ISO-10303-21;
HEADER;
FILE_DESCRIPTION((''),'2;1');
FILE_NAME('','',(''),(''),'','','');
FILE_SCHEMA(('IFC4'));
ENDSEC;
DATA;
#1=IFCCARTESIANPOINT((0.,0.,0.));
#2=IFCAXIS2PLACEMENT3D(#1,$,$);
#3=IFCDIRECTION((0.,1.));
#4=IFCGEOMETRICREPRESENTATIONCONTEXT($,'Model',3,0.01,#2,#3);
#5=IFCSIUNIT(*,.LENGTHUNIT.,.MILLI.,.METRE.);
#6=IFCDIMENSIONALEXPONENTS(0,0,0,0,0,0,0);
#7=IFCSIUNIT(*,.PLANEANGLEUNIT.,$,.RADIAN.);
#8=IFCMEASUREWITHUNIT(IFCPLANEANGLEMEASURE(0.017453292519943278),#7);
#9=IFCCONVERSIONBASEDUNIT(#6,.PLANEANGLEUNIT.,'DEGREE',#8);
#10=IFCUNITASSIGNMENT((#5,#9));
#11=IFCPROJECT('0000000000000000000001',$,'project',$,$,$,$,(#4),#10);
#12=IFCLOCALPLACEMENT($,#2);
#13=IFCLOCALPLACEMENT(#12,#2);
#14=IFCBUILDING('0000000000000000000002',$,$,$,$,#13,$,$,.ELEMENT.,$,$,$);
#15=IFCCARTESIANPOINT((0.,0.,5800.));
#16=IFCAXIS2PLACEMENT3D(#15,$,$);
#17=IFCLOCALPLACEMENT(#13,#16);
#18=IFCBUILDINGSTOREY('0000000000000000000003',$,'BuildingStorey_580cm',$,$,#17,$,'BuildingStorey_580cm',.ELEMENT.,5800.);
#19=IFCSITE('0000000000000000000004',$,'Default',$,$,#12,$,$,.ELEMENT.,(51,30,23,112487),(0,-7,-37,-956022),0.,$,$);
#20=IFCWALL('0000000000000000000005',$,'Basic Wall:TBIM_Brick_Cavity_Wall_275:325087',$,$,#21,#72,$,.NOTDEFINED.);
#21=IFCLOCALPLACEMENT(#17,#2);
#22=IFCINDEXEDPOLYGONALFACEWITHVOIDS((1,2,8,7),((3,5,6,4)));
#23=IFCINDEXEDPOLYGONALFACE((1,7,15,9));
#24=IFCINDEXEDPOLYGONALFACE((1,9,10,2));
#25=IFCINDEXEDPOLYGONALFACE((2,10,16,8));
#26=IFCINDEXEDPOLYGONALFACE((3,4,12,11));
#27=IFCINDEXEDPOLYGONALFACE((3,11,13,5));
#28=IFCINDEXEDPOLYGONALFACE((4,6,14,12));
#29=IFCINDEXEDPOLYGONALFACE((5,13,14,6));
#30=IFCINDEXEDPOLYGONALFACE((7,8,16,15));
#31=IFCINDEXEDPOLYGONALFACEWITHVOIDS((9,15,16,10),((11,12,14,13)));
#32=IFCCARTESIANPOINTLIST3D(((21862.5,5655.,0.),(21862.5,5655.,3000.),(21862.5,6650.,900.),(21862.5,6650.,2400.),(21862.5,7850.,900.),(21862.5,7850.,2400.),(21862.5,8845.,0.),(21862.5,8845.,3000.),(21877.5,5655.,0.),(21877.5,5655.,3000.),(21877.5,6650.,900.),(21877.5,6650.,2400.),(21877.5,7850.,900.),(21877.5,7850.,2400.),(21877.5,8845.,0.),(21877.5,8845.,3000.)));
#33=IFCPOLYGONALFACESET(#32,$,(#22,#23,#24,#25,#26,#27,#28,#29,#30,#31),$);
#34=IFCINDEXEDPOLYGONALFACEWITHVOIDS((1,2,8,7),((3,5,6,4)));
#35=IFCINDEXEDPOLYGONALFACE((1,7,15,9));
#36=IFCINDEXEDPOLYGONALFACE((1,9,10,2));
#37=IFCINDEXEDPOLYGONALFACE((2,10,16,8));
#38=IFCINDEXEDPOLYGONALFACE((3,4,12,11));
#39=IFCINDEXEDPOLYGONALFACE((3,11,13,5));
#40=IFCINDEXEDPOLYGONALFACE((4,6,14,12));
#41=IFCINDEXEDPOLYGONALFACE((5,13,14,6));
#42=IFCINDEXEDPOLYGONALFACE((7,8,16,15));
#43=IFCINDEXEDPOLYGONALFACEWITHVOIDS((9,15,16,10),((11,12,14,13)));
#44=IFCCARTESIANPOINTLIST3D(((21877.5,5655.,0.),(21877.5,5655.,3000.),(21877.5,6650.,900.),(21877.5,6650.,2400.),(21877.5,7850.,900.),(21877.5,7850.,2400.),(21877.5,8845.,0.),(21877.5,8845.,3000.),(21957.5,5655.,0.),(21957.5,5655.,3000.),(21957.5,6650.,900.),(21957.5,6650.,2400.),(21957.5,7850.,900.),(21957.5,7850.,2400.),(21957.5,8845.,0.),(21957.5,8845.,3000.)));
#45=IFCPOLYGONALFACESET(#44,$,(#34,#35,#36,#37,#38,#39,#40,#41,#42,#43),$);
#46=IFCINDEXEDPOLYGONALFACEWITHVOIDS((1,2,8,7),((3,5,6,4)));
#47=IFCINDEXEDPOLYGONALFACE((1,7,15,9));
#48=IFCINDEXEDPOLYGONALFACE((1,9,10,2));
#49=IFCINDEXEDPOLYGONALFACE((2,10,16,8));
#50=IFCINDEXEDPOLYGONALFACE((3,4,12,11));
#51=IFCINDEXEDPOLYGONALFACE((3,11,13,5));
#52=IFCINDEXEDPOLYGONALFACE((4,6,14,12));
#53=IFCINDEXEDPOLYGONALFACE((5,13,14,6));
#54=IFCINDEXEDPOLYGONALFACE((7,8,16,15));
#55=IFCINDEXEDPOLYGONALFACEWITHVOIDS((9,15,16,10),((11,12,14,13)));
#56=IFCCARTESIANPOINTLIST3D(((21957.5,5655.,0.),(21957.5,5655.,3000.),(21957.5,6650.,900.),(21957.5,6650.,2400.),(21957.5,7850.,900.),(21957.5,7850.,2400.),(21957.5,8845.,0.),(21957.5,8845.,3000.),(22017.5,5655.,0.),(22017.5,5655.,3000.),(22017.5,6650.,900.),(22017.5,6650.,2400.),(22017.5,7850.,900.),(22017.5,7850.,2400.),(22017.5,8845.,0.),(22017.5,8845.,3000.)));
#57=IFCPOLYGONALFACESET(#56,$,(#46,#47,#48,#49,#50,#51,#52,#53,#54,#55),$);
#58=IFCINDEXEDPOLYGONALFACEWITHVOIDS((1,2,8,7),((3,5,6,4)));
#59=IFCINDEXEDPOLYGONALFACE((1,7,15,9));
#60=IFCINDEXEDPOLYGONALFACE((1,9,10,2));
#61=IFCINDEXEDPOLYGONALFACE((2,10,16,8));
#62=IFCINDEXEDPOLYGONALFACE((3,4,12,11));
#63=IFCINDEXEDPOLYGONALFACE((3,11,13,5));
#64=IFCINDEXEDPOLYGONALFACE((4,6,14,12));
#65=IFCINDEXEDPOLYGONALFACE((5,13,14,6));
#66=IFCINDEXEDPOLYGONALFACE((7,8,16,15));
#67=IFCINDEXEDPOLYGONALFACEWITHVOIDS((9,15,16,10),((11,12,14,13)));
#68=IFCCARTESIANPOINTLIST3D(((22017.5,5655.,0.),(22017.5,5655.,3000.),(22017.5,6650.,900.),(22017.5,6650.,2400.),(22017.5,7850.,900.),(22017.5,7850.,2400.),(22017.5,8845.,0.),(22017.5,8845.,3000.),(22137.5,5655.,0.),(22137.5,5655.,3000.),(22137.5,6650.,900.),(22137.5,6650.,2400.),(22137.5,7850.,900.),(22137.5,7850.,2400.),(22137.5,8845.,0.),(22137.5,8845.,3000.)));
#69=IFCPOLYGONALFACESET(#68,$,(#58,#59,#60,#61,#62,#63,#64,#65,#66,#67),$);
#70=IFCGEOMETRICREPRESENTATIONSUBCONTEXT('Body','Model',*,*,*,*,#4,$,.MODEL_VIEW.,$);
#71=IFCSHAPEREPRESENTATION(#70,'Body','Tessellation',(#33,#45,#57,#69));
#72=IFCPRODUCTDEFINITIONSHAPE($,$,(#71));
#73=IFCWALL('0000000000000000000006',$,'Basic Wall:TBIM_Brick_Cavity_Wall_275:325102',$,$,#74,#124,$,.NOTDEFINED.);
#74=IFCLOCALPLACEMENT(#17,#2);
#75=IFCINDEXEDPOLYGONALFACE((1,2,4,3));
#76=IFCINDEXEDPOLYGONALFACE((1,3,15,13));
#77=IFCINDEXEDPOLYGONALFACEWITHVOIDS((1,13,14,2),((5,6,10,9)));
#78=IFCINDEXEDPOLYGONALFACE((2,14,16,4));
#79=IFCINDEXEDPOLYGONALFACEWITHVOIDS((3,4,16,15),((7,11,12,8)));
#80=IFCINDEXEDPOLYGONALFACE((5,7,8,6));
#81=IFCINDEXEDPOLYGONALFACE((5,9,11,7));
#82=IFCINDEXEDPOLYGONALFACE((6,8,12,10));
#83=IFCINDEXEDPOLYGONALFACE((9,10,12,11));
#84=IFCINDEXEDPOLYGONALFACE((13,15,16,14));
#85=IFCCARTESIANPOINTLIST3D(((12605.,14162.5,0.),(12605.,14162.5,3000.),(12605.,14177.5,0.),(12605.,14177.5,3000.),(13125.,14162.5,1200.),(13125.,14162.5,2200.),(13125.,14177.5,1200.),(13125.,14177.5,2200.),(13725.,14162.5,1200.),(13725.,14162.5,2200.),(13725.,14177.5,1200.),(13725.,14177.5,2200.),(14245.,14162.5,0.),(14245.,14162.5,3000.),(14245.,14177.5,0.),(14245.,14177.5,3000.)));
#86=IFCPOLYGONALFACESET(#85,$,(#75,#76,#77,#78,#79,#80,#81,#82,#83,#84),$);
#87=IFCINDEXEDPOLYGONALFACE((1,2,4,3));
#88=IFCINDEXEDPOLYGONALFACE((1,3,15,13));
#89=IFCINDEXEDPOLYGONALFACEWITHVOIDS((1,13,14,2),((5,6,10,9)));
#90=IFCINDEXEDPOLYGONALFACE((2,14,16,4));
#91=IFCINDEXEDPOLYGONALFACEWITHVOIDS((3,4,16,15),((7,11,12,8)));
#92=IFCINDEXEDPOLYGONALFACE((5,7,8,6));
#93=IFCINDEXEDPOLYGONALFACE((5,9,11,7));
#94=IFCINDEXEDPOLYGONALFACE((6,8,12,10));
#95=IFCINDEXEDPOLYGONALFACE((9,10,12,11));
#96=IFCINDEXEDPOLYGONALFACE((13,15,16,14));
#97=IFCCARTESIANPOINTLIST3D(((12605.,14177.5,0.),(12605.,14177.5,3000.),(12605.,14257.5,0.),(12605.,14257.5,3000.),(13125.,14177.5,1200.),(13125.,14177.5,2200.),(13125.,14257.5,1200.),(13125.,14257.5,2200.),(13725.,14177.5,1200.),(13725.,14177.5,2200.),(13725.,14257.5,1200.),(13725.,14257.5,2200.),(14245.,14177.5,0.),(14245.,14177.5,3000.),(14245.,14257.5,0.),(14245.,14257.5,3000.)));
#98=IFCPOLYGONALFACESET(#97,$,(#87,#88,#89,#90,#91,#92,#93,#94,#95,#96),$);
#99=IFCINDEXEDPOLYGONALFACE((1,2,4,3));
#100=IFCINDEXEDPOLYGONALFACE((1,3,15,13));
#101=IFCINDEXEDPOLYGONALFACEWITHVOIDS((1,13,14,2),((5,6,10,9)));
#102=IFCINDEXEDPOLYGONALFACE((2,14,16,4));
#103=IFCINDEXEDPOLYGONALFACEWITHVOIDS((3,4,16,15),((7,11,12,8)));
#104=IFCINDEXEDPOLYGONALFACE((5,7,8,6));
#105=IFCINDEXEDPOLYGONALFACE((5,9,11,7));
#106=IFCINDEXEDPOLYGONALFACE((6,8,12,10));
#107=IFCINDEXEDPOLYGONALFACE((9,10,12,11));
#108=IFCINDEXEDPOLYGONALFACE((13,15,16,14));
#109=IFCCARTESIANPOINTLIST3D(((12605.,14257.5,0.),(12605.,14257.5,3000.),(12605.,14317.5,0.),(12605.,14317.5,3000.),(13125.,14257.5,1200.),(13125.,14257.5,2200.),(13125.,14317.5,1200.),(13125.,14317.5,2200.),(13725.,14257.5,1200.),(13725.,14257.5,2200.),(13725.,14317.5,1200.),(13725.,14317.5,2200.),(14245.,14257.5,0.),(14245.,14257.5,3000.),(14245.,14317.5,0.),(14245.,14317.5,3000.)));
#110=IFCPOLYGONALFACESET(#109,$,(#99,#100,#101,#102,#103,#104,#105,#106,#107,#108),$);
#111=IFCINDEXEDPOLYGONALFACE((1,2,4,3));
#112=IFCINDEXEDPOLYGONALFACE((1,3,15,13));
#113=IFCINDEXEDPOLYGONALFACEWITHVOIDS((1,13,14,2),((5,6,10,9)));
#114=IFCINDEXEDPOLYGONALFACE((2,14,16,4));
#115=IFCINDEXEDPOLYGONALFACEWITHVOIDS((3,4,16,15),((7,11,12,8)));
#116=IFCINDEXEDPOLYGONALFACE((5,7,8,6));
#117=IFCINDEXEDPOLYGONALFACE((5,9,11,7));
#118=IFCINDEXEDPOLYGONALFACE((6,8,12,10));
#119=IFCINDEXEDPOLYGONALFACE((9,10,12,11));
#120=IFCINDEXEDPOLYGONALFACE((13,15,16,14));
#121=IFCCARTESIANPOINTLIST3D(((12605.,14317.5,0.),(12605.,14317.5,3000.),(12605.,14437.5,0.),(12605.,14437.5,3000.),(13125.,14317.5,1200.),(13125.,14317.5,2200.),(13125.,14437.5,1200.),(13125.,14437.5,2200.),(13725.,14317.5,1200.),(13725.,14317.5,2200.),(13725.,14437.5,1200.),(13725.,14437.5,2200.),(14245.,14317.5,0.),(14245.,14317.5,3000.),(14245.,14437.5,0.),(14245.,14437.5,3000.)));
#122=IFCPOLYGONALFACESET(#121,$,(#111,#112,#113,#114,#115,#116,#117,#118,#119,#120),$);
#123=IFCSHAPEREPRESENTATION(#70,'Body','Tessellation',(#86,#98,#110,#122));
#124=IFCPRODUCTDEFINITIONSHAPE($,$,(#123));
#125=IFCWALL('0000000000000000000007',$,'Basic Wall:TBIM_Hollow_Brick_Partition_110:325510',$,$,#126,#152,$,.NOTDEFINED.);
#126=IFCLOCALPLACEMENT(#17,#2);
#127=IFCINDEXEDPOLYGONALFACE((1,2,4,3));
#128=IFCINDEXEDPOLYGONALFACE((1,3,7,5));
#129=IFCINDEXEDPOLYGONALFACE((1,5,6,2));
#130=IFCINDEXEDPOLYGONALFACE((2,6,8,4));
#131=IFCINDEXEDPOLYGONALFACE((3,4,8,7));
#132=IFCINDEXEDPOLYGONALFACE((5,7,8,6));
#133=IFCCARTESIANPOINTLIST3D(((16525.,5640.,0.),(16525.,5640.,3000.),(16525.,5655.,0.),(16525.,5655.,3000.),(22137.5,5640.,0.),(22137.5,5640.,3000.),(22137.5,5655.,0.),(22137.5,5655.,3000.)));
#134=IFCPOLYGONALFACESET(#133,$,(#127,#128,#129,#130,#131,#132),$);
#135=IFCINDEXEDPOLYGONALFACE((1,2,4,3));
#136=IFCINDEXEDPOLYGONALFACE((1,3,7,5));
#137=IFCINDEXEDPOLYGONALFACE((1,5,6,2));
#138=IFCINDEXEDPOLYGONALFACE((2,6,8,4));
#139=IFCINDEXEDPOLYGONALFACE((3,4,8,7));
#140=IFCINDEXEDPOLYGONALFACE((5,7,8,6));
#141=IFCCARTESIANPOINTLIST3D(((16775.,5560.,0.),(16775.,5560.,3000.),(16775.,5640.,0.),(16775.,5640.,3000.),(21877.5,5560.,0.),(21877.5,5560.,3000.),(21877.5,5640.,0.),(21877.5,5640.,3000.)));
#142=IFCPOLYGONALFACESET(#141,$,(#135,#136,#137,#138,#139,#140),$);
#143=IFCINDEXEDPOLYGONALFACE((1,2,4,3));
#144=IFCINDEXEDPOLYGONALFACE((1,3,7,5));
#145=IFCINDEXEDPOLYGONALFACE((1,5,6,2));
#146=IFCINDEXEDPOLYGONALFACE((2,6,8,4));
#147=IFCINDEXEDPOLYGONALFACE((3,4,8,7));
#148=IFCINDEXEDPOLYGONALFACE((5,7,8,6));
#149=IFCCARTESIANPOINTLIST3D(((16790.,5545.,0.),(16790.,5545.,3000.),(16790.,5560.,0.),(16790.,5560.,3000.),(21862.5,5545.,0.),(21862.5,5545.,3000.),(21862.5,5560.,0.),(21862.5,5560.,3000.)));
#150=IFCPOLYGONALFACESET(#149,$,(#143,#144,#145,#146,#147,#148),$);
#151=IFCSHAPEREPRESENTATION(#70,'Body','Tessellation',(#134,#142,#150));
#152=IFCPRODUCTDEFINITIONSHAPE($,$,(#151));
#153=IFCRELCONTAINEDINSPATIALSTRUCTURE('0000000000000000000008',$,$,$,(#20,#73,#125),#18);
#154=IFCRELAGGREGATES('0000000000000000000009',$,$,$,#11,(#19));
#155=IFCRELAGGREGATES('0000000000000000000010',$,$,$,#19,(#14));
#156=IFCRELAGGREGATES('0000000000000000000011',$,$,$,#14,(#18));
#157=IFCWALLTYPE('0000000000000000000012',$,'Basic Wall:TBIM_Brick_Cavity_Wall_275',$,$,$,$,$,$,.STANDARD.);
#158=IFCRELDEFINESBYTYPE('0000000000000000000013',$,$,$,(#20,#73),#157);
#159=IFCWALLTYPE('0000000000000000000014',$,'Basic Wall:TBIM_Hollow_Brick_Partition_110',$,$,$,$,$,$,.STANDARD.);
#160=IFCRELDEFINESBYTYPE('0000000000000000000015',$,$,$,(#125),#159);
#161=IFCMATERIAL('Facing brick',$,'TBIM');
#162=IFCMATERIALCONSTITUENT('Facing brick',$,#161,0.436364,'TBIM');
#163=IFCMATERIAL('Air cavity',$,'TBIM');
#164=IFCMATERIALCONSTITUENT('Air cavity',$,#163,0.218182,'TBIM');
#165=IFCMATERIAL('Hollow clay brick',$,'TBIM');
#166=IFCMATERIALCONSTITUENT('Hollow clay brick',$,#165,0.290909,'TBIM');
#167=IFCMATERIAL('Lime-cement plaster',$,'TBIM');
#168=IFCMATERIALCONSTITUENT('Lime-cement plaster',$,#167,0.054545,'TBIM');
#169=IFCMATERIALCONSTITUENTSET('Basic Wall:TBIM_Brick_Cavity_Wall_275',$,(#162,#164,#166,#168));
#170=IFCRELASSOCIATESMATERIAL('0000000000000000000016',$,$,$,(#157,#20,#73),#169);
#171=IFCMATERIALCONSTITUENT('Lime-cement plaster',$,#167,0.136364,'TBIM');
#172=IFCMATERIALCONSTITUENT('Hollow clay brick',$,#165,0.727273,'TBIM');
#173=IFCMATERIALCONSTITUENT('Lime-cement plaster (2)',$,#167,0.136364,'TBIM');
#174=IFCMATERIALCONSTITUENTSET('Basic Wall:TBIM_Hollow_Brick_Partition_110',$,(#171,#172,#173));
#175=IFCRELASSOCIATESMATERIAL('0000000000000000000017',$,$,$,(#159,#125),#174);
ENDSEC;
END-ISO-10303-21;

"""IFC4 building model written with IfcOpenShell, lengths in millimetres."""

from ifc_helpers import new_model, entity, si_unit, converted_unit, direction, frame, origin, place, context, subcontext, project, spatial, indexed_curve, outline, extrude, material, constituent, constituent_set, type_object, element, save


model = new_model("IFC4")

# Units and contexts
model_context = context("Model", 3, precision=0.01, world=origin(), true_north=direction((0.0, 1.0)))
body_context = subcontext(model_context, "Body", "Model", "MODEL_VIEW")
ifc_project = project(units=[si_unit("LENGTHUNIT", "METRE", prefix="MILLI"), converted_unit("PLANEANGLEUNIT", "DEGREE", entity("IfcPlaneAngleMeasure", 0.017453292519943278), si_unit("PLANEANGLEUNIT", "RADIAN"), dimensions=[0, 0, 0, 0, 0, 0, 0])], contexts=[model_context])

# Site, building, storey
site_placement = place(None, origin())
site = spatial("IfcSite", under=ifc_project, at=site_placement, Name="Default", CompositionType="ELEMENT", RefLatitude=(51, 30, 23, 112487), RefLongitude=(0, -7, -37, -956022), RefElevation=0.0)
building_placement = place(site_placement, origin())
building = spatial("IfcBuilding", under=site, at=building_placement, CompositionType="ELEMENT")
storey_placement = place(building_placement, frame((0.0, 0.0, 5800.0)))
storey = spatial("IfcBuildingStorey", under=building, at=storey_placement, Name="BuildingStorey_580cm", LongName="BuildingStorey_580cm", CompositionType="ELEMENT", Elevation=5800.0)

# Walls, openings
ifc_material_1 = material(Name="Facing brick", Category="TBIM")
ifc_constituent_1 = constituent(ifc_material_1, Name="Facing brick", Category="TBIM", fraction=0.436364)
ifc_material_2 = material(Name="Air cavity", Category="TBIM")
ifc_constituent_2 = constituent(ifc_material_2, Name="Air cavity", Category="TBIM", fraction=0.218182)
ifc_material_3 = material(Name="Hollow clay brick", Category="TBIM")
ifc_constituent_3 = constituent(ifc_material_3, Name="Hollow clay brick", Category="TBIM", fraction=0.290909)
ifc_material_4 = material(Name="Lime-cement plaster", Category="TBIM")
ifc_constituent_4 = constituent(ifc_material_4, Name="Lime-cement plaster", Category="TBIM", fraction=0.054545)
ifc_constituent_set_1 = constituent_set(constituents=[ifc_constituent_1, ifc_constituent_2, ifc_constituent_3, ifc_constituent_4], Name="Basic Wall:TBIM_Brick_Cavity_Wall_275")
wall_type_1 = type_object("IfcWallType", Name="Basic Wall:TBIM_Brick_Cavity_Wall_275", PredefinedType="STANDARD", material=ifc_constituent_set_1)
wall_1_placement = place(storey_placement, frame((22000.0, 5655.0, 0.0), z_axis=(0.0, 0.0, 1.0), x_axis=(0.0, 1.0, 0.0)))
wall_1 = element("IfcWall", 1, at=wall_1_placement, inside=storey, type_object=wall_type_1, material=ifc_constituent_set_1, Name="Basic Wall:TBIM_Brick_Cavity_Wall_275:325087", PredefinedType="NOTDEFINED", context=body_context, shape_type="SweptSolid", body=[
    extrude(outline(indexed_curve([(-1595.0, -1500.0), (1595.0, -1500.0), (1595.0, 1500.0), (-1595.0, 1500.0), (-1595.0, -1500.0)], self_intersect=False), holes=[indexed_curve([(-600.0, 900.0), (600.0, 900.0), (600.0, -600.0), (-600.0, -600.0), (-600.0, 900.0)], self_intersect=False)]), frame((1595.0, 137.5, 1500.0), z_axis=(0.0, -1.0, 0.0), x_axis=(1.0, 0.0, 0.0)), (0.0, 0.0, 1.0), 15.0),
    extrude(outline(indexed_curve([(-1500.0, -1595.0), (1500.0, -1595.0), (1500.0, 1595.0), (-1500.0, 1595.0), (-1500.0, -1595.0)], self_intersect=False), holes=[indexed_curve([(900.0, 600.0), (900.0, -600.0), (-600.0, -600.0), (-600.0, 600.0), (900.0, 600.0)], self_intersect=False)]), frame((1595.0, 122.5, 1500.0), z_axis=(0.0, -1.0, 0.0), x_axis=(0.0, 0.0, 1.0)), (0.0, 0.0, 1.0), 80.0),
    extrude(outline(indexed_curve([(-1500.0, -1595.0), (1500.0, -1595.0), (1500.0, 1595.0), (-1500.0, 1595.0), (-1500.0, -1595.0)], self_intersect=False), holes=[indexed_curve([(900.0, 600.0), (900.0, -600.0), (-600.0, -600.0), (-600.0, 600.0), (900.0, 600.0)], self_intersect=False)]), frame((1595.0, 42.5, 1500.0), z_axis=(0.0, -1.0, 0.0), x_axis=(0.0, 0.0, 1.0)), (0.0, 0.0, 1.0), 60.0),
    extrude(outline(indexed_curve([(-1500.0, -1595.0), (1500.0, -1595.0), (1500.0, 1595.0), (-1500.0, 1595.0), (-1500.0, -1595.0)], self_intersect=False), holes=[indexed_curve([(900.0, 600.0), (900.0, -600.0), (-600.0, -600.0), (-600.0, 600.0), (900.0, 600.0)], self_intersect=False)]), frame((1595.0, -17.5, 1500.0), z_axis=(0.0, -1.0, 0.0), x_axis=(0.0, 0.0, 1.0)), (0.0, 0.0, 1.0), 120.0),
])
opening_1_placement = place(wall_1_placement, frame((995.0, -137.5, 900.0)))
element("IfcOpeningElement", 2, at=opening_1_placement, cuts=wall_1, PredefinedType="OPENING", context=body_context, shape_type="SweptSolid", body=[
    extrude(outline(indexed_curve([(1500.0, 0.0), (1500.0, 1200.0), (0.0, 1200.0), (0.0, 0.0), (1500.0, 0.0)], self_intersect=False)), frame((0.0, 0.0, 0.0), z_axis=(0.0, 1.0, 0.0), x_axis=(0.0, 0.0, 1.0)), (0.0, 0.0, 1.0), 275.0),
])
wall_2_placement = place(storey_placement, frame((14245.0, 14300.0, 0.0), z_axis=(0.0, 0.0, 1.0), x_axis=(-1.0, 0.0, 0.0)))
wall_2 = element("IfcWall", 3, at=wall_2_placement, inside=storey, type_object=wall_type_1, material=ifc_constituent_set_1, Name="Basic Wall:TBIM_Brick_Cavity_Wall_275:325102", PredefinedType="NOTDEFINED", context=body_context, shape_type="SweptSolid", body=[
    extrude(outline(indexed_curve([(-820.0, -1500.0), (820.0, -1500.0), (820.0, 1500.0), (-820.0, 1500.0), (-820.0, -1500.0)], self_intersect=False), holes=[indexed_curve([(-300.0, 700.0), (300.0, 700.0), (300.0, -300.0), (-300.0, -300.0), (-300.0, 700.0)], self_intersect=False)]), frame((820.0, 137.5, 1500.0), z_axis=(0.0, -1.0, 0.0), x_axis=(1.0, 0.0, 0.0)), (0.0, 0.0, 1.0), 15.0),
    extrude(outline(indexed_curve([(-1500.0, -820.0), (1500.0, -820.0), (1500.0, 820.0), (-1500.0, 820.0), (-1500.0, -820.0)], self_intersect=False), holes=[indexed_curve([(700.0, 300.0), (700.0, -300.0), (-300.0, -300.0), (-300.0, 300.0), (700.0, 300.0)], self_intersect=False)]), frame((820.0, 122.5, 1500.0), z_axis=(0.0, -1.0, 0.0), x_axis=(0.0, 0.0, 1.0)), (0.0, 0.0, 1.0), 80.0),
    extrude(outline(indexed_curve([(-1500.0, -820.0), (1500.0, -820.0), (1500.0, 820.0), (-1500.0, 820.0), (-1500.0, -820.0)], self_intersect=False), holes=[indexed_curve([(700.0, 300.0), (700.0, -300.0), (-300.0, -300.0), (-300.0, 300.0), (700.0, 300.0)], self_intersect=False)]), frame((820.0, 42.5, 1500.0), z_axis=(0.0, -1.0, 0.0), x_axis=(0.0, 0.0, 1.0)), (0.0, 0.0, 1.0), 60.0),
    extrude(outline(indexed_curve([(-1500.0, -820.0), (1500.0, -820.0), (1500.0, 820.0), (-1500.0, 820.0), (-1500.0, -820.0)], self_intersect=False), holes=[indexed_curve([(700.0, 300.0), (700.0, -300.0), (-300.0, -300.0), (-300.0, 300.0), (700.0, 300.0)], self_intersect=False)]), frame((820.0, -17.5, 1500.0), z_axis=(0.0, -1.0, 0.0), x_axis=(0.0, 0.0, 1.0)), (0.0, 0.0, 1.0), 120.0),
])
opening_2_placement = place(wall_2_placement, frame((520.0, -137.5, 1200.0)))
element("IfcOpeningElement", 4, at=opening_2_placement, cuts=wall_2, PredefinedType="OPENING", context=body_context, shape_type="SweptSolid", body=[
    extrude(outline(indexed_curve([(1000.0, 0.0), (1000.0, 600.0), (0.0, 600.0), (0.0, 0.0), (1000.0, 0.0)], self_intersect=False)), frame((0.0, 0.0, 0.0), z_axis=(0.0, 1.0, 0.0), x_axis=(0.0, 0.0, 1.0)), (0.0, 0.0, 1.0), 275.0),
])
ifc_constituent_5 = constituent(ifc_material_4, Name="Lime-cement plaster", Category="TBIM", fraction=0.136364)
ifc_constituent_6 = constituent(ifc_material_3, Name="Hollow clay brick", Category="TBIM", fraction=0.727273)
ifc_constituent_7 = constituent(ifc_material_4, Name="Lime-cement plaster (2)", Category="TBIM", fraction=0.136364)
ifc_constituent_set_2 = constituent_set(constituents=[ifc_constituent_5, ifc_constituent_6, ifc_constituent_7], Name="Basic Wall:TBIM_Hollow_Brick_Partition_110")
wall_type_2 = type_object("IfcWallType", Name="Basic Wall:TBIM_Hollow_Brick_Partition_110", PredefinedType="STANDARD", material=ifc_constituent_set_2)

# Wall
wall_3_placement = place(storey_placement, frame((16790.0, 5600.0, 0.0)))
element("IfcWall", 5, at=wall_3_placement, inside=storey, type_object=wall_type_2, material=ifc_constituent_set_2, Name="Basic Wall:TBIM_Hollow_Brick_Partition_110:325510", PredefinedType="NOTDEFINED", context=body_context, shape_type="SweptSolid", body=[
    extrude(outline(indexed_curve([(-7.5, -2806.3), (7.5, -2806.3), (7.5, 2806.3), (-7.5, 2806.3), (-7.5, -2806.3)], self_intersect=False)), frame((2541.3, 47.5, 0.0), z_axis=(0.0, 0.0, 1.0), x_axis=(0.0, -1.0, 0.0)), (0.0, 0.0, 1.0), 3000.0),
    extrude(outline(indexed_curve([(-2551.3, -40.0), (2551.3, -40.0), (2551.3, 40.0), (-2551.3, 40.0), (-2551.3, -40.0)], self_intersect=False)), frame((2536.3, 0.0, 0.0)), (0.0, 0.0, 1.0), 3000.0),
    extrude(outline(indexed_curve([(-7.5, -2536.3), (7.5, -2536.3), (7.5, 2536.3), (-7.5, 2536.3), (-7.5, -2536.3)], self_intersect=False)), frame((2536.3, -47.5, 0.0), z_axis=(0.0, 0.0, 1.0), x_axis=(0.0, 1.0, 0.0)), (0.0, 0.0, 1.0), 3000.0),
])

save(model, "model.ifc")
